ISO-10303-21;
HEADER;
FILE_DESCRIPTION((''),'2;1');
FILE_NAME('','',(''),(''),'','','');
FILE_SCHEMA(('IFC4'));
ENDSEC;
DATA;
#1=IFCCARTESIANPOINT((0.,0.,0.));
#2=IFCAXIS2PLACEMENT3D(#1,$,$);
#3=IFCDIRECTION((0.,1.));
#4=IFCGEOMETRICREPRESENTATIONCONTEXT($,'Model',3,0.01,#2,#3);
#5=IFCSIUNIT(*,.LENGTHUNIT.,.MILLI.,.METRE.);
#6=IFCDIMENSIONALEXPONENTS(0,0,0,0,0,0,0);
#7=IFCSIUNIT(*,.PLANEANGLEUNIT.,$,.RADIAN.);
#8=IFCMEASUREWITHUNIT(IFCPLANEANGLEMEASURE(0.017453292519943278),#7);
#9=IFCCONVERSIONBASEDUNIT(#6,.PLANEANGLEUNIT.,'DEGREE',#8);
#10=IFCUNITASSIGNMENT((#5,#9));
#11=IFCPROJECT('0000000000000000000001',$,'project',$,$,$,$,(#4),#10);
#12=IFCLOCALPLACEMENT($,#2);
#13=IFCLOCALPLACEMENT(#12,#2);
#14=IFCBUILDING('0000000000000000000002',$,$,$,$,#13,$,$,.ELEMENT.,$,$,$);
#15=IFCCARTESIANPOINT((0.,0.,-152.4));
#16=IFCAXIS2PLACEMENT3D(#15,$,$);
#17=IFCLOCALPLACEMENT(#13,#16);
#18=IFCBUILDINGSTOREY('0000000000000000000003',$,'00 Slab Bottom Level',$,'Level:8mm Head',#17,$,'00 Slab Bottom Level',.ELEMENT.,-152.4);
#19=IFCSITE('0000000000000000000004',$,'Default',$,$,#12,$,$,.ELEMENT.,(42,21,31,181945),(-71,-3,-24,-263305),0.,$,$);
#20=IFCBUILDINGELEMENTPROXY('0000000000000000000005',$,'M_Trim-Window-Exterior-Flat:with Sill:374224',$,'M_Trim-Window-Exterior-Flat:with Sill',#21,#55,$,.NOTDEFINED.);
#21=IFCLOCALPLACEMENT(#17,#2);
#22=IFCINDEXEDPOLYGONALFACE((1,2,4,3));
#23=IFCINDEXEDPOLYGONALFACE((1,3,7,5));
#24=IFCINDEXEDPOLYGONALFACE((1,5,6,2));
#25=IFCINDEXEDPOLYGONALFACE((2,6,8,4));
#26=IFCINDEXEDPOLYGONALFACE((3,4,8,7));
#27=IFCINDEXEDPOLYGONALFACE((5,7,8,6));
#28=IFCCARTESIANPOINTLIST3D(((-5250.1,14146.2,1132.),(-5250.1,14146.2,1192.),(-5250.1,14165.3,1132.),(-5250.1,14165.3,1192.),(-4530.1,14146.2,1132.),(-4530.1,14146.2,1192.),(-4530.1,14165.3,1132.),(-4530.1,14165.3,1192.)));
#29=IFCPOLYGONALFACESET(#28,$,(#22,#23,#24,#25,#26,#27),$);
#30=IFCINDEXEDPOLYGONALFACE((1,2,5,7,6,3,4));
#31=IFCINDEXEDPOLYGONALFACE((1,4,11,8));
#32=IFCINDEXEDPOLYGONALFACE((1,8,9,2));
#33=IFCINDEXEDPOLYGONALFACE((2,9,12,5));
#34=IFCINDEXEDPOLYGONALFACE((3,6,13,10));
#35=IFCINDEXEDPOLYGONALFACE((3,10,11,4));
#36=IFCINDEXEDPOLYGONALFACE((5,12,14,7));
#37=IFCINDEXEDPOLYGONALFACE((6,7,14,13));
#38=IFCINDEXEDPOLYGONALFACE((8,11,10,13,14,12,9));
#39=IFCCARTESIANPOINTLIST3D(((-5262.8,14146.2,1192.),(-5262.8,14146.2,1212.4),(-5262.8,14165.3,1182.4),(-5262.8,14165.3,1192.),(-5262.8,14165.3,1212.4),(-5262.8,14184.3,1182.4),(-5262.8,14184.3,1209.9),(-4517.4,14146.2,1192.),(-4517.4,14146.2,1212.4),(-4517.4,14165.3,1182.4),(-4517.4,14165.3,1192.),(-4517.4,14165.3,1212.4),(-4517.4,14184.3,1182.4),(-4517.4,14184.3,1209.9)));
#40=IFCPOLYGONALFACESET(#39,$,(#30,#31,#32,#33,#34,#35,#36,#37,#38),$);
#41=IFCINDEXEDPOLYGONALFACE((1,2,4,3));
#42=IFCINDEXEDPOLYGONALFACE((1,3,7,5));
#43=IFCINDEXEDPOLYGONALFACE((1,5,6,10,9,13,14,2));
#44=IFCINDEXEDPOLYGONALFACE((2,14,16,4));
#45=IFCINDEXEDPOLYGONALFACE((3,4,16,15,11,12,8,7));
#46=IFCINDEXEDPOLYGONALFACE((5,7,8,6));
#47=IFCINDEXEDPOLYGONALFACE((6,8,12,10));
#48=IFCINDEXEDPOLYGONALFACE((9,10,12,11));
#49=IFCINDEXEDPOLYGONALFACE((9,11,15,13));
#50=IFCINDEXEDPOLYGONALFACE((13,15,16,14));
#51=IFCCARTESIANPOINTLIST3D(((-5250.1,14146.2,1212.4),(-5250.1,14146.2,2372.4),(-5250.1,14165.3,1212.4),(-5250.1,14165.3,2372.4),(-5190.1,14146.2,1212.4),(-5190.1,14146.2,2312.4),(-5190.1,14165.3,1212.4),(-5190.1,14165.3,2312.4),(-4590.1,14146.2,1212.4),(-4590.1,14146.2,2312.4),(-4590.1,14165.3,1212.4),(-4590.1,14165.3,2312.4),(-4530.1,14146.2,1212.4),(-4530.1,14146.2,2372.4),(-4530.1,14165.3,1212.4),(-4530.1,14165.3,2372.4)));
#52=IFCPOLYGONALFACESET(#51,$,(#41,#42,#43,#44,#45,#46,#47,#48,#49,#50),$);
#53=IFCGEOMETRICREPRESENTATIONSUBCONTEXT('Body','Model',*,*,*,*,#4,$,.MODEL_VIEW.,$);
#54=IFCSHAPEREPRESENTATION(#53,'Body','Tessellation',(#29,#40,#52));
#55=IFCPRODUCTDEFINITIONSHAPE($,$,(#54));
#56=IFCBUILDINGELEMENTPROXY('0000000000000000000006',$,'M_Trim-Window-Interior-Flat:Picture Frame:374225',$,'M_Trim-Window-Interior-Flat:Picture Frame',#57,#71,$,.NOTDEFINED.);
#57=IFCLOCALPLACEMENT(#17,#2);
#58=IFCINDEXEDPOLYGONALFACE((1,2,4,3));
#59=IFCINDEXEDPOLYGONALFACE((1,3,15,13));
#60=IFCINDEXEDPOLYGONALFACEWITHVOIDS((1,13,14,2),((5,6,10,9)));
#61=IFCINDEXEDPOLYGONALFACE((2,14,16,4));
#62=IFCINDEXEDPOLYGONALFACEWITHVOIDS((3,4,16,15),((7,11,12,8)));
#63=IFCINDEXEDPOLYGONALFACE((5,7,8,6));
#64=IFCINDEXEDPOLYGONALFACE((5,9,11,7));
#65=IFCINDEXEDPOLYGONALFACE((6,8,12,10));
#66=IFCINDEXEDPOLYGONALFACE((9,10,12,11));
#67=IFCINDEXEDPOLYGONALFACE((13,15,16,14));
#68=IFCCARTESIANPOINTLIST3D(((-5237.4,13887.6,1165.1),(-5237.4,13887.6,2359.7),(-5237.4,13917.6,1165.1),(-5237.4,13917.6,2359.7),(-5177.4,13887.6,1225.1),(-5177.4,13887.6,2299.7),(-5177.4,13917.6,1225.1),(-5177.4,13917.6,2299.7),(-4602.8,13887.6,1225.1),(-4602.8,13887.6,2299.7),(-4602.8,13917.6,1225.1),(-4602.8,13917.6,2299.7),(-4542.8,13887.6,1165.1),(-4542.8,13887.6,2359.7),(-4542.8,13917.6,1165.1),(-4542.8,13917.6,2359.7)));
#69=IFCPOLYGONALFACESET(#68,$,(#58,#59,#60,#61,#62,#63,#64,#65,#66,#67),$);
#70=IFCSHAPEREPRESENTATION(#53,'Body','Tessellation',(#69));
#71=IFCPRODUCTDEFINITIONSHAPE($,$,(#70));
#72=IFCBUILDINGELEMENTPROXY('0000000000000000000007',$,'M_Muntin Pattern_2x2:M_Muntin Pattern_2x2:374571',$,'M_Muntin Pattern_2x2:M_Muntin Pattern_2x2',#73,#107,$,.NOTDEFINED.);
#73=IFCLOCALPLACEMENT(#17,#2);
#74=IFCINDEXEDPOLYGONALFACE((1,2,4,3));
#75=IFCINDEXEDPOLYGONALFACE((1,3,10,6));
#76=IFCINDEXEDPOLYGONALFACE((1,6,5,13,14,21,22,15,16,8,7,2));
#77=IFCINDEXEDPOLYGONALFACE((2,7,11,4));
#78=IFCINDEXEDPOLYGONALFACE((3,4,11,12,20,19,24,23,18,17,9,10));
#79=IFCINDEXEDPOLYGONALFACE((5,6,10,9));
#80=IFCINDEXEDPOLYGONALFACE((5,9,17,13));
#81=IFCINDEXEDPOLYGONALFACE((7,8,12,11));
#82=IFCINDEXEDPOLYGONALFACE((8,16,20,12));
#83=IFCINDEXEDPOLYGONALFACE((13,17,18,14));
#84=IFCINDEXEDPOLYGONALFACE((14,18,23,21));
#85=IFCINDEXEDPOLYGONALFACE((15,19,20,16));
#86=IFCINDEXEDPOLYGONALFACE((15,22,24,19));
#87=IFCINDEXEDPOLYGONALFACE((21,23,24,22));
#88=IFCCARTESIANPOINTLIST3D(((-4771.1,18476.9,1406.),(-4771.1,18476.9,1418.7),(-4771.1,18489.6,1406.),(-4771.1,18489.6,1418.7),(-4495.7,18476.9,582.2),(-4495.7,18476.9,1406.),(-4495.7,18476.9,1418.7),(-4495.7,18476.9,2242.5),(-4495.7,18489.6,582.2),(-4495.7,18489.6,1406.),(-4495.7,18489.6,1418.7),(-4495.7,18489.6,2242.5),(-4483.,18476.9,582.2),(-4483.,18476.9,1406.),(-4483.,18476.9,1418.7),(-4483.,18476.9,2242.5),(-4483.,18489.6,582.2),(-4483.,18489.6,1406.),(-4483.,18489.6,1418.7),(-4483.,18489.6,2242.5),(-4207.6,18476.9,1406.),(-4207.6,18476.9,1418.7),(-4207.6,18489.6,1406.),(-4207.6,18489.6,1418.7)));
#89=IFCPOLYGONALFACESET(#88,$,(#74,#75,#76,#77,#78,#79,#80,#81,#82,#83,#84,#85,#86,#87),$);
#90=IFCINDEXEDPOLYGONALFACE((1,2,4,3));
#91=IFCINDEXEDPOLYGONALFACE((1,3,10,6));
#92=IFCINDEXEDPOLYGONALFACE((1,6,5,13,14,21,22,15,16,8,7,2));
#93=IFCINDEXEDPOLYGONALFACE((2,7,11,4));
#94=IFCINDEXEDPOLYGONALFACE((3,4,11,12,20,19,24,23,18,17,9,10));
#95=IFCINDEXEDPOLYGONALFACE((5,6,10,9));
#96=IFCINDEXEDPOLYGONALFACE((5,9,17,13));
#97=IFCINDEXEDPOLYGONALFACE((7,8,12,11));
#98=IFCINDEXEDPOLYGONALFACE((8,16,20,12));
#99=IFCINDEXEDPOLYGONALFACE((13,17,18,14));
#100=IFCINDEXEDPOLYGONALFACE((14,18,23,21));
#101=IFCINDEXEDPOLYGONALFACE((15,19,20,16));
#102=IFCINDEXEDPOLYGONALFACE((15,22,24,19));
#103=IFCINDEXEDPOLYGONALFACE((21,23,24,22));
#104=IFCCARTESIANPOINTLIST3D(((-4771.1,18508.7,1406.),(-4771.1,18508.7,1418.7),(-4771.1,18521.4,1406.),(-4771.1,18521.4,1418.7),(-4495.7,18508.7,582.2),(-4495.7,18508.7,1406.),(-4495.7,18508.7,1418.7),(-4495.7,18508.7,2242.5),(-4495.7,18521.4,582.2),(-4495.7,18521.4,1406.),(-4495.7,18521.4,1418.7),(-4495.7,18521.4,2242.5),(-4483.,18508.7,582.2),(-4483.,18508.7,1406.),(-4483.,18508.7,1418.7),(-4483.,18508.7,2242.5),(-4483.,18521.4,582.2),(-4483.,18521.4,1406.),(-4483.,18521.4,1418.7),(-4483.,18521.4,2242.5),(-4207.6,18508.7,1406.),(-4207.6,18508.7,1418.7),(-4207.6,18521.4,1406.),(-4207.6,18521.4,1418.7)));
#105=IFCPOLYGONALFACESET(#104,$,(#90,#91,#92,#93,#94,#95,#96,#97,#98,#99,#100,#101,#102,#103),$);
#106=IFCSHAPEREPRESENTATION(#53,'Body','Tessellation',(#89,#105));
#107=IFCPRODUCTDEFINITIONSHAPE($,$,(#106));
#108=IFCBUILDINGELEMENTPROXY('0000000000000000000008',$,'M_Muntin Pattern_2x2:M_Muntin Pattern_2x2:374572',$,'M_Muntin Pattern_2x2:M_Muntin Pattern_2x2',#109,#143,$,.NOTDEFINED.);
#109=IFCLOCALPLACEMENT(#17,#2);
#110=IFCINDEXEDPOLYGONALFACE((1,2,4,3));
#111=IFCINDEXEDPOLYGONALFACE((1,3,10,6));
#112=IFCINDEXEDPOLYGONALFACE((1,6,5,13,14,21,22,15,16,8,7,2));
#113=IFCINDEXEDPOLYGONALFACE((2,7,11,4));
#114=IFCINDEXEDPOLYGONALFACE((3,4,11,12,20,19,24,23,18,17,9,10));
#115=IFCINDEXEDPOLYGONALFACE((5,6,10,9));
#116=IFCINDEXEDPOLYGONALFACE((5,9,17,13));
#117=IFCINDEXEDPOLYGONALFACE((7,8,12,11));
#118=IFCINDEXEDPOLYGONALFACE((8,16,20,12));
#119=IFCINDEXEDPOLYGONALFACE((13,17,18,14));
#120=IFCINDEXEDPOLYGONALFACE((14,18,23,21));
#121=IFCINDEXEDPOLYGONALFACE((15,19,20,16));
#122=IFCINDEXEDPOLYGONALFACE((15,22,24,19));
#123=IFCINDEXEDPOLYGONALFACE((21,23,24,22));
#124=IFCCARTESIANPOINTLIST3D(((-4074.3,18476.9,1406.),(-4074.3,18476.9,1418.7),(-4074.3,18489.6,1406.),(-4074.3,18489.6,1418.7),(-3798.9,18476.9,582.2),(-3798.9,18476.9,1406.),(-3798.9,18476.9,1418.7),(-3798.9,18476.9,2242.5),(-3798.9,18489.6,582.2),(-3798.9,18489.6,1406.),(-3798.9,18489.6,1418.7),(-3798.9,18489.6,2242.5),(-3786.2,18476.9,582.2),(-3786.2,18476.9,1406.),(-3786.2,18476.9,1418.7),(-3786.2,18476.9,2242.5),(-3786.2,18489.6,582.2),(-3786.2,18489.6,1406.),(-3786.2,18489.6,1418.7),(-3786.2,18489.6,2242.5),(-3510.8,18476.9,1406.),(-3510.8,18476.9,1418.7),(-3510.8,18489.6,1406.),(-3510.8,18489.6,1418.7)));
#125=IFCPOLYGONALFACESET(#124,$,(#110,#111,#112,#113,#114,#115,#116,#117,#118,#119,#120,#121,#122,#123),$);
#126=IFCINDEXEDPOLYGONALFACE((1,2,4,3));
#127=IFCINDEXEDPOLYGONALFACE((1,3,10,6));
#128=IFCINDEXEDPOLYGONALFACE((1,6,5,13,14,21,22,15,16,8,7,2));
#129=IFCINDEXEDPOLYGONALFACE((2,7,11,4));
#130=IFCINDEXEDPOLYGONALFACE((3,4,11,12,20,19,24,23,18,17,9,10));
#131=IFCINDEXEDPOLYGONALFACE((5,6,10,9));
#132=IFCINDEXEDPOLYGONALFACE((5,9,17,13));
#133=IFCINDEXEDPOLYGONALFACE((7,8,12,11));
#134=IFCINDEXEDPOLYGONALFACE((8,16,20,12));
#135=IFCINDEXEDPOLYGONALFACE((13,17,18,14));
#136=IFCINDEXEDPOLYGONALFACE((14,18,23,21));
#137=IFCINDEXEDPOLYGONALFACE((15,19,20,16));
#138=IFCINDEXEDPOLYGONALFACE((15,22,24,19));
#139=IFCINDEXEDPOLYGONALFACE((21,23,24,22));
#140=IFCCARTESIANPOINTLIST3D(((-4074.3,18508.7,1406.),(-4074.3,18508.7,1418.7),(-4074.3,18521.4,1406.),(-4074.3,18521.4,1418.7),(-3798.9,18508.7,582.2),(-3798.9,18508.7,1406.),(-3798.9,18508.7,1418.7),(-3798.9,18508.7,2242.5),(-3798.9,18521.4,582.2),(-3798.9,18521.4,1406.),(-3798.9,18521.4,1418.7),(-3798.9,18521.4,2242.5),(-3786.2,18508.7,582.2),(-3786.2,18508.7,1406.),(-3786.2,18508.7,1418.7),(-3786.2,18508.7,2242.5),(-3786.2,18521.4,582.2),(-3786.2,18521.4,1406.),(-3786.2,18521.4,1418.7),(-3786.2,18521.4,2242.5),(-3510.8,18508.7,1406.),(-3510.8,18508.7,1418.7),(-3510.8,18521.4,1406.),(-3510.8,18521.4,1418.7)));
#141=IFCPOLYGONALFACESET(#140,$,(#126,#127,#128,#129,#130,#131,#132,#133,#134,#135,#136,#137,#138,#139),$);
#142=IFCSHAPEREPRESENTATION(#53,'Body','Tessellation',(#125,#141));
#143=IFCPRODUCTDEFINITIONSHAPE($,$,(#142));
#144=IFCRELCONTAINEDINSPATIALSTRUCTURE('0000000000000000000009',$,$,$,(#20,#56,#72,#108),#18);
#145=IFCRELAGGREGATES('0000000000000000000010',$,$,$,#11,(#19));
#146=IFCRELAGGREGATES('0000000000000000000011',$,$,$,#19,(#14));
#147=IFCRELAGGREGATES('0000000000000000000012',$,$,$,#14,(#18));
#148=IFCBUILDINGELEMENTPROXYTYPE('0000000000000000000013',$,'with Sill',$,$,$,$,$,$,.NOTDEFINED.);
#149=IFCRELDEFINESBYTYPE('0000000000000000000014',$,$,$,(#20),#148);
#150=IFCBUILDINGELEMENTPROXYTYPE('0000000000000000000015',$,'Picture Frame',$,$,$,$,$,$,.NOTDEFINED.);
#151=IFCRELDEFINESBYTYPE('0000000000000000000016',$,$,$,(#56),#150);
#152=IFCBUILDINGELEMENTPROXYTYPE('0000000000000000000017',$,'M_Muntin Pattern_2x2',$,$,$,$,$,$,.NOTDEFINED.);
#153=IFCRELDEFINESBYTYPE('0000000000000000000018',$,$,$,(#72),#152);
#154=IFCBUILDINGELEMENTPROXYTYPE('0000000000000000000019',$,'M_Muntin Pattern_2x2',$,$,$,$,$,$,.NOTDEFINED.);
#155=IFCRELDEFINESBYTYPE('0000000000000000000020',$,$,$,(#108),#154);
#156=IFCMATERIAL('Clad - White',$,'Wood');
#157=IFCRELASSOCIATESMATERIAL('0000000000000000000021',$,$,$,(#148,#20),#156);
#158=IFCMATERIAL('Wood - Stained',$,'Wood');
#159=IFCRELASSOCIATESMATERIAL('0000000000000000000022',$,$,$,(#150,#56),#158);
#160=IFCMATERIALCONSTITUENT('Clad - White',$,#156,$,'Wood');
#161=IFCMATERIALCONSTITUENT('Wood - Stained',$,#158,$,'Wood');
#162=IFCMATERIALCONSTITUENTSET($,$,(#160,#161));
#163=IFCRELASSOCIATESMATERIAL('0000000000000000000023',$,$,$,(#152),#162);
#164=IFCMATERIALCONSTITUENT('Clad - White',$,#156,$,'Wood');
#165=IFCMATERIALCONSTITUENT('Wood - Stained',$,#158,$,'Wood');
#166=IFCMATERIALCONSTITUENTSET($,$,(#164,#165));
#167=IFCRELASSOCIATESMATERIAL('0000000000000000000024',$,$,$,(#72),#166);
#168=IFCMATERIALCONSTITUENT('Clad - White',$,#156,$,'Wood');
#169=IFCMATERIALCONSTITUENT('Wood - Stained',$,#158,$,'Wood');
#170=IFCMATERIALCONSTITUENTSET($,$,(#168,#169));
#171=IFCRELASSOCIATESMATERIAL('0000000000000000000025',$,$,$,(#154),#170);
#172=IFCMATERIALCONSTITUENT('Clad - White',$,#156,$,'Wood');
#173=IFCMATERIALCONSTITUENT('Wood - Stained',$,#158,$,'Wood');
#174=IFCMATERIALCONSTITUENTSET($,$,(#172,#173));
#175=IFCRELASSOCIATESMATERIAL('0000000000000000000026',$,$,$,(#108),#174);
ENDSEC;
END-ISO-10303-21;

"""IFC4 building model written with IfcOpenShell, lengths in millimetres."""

from ifc_helpers import new_model, entity, si_unit, converted_unit, direction, frame, origin, place, context, subcontext, project, spatial, indexed_curve, outline, extrude, source, transform, mapped, material, constituent, constituent_set, type_object, type_shapes, element, save


model = new_model("IFC4")

# Units and contexts
model_context = context("Model", 3, precision=0.01, world=origin(), true_north=direction((0.0, 1.0)))
body_context = subcontext(model_context, "Body", "Model", "MODEL_VIEW")
ifc_project = project(units=[si_unit("LENGTHUNIT", "METRE", prefix="MILLI"), converted_unit("PLANEANGLEUNIT", "DEGREE", entity("IfcPlaneAngleMeasure", 0.017453292519943278), si_unit("PLANEANGLEUNIT", "RADIAN"), dimensions=[0, 0, 0, 0, 0, 0, 0])], contexts=[model_context])

# Site, building, storey
site_placement = place(None, origin())
site = spatial("IfcSite", under=ifc_project, at=site_placement, Name="Default", CompositionType="ELEMENT", RefLatitude=(42, 21, 31, 181945), RefLongitude=(-71, -3, -24, -263305), RefElevation=0.0)
building_placement = place(site_placement, origin())
building = spatial("IfcBuilding", under=site, at=building_placement, CompositionType="ELEMENT")
storey_placement = place(building_placement, frame((0.0, 0.0, -152.4)))
storey = spatial("IfcBuildingStorey", under=building, at=storey_placement, Name="00 Slab Bottom Level", ObjectType="Level:8mm Head", LongName="00 Slab Bottom Level", CompositionType="ELEMENT", Elevation=-152.4)

# Building element proxies
ifc_material_1 = material(Name="Clad - White", Category="Wood")
ifc_material_2 = material(Name="Wood - Stained", Category="Wood")
building_element_proxy_type_1 = type_object("IfcBuildingElementProxyType", Name="with Sill", PredefinedType="NOTDEFINED", material=ifc_material_1)
shared_shape_1 = source(origin(), body_context, "Body", "SweptSolid", [
    extrude(outline(indexed_curve([(-360.0, -30.0), (360.0, -30.0), (360.0, 30.0), (-360.0, 30.0), (-360.0, -30.0)], self_intersect=False)), frame((0.0, -1150.4, 0.0), z_axis=(0.0, 0.0, 1.0), x_axis=(-1.0, 0.0, 0.0)), (0.0, 0.0, 1.0), 19.0),
    extrude(outline(indexed_curve([(-19.0, -15.2), (0.0, -15.2), (0.0, -5.7), (19.0, -5.7), (19.0, 14.8), (0.0, 14.8), (-19.0, 12.3), (-19.0, -15.2)], self_intersect=False)), frame((-372.7, -1114.8, 19.0), z_axis=(1.0, 0.0, 0.0), x_axis=(0.0, 0.0, -1.0)), (0.0, 0.0, 1.0), 745.4),
    extrude(outline(indexed_curve([(-595.0, -360.0), (565.0, -360.0), (565.0, -300.0), (-535.0, -300.0), (-535.0, 300.0), (565.0, 300.0), (565.0, 360.0), (-595.0, 360.0), (-595.0, -360.0)], self_intersect=False)), frame((0.0, -535.0, 0.0), z_axis=(0.0, 0.0, 1.0), x_axis=(0.0, -1.0, 0.0)), (0.0, 0.0, 1.0), 19.0),
])
type_shapes(building_element_proxy_type_1, [shared_shape_1])
proxy_1_placement = place(storey_placement, frame((-4890.1, 14146.2, 2312.4), z_axis=(0.0, 1.0, 0.0), x_axis=(-1.0, 0.0, 0.0)))
element("IfcBuildingElementProxy", 1, at=proxy_1_placement, inside=storey, type_object=building_element_proxy_type_1, material=ifc_material_1, Name="M_Trim-Window-Exterior-Flat:with Sill:374224", ObjectType="M_Trim-Window-Exterior-Flat:with Sill", PredefinedType="NOTDEFINED", context=body_context, shape_type="MappedRepresentation", body=[
    mapped(shared_shape_1, transform((0.0, 0.0, 0.0), scale=1.0)),
])
building_element_proxy_type_2 = type_object("IfcBuildingElementProxyType", Name="Picture Frame", PredefinedType="NOTDEFINED", material=ifc_material_2)
shared_shape_2 = source(origin(), body_context, "Body", "SweptSolid", [
    extrude(outline(indexed_curve([(-347.3, -597.3), (347.3, -597.3), (347.3, 597.3), (-347.3, 597.3), (-347.3, -597.3)], self_intersect=False), holes=[indexed_curve([(-287.3, -537.3), (-287.3, 537.3), (287.3, 537.3), (287.3, -537.3), (-287.3, -537.3)], self_intersect=False)]), frame((0.0, -550.0, 0.0), z_axis=(0.0, 0.0, 1.0), x_axis=(-1.0, 0.0, 0.0)), (0.0, 0.0, 1.0), 30.0),
])
type_shapes(building_element_proxy_type_2, [shared_shape_2])
proxy_2_placement = place(storey_placement, frame((-4890.1, 13917.6, 2312.4), z_axis=(0.0, -1.0, 0.0), x_axis=(1.0, 0.0, 0.0)))
element("IfcBuildingElementProxy", 2, at=proxy_2_placement, inside=storey, type_object=building_element_proxy_type_2, material=ifc_material_2, Name="M_Trim-Window-Interior-Flat:Picture Frame:374225", ObjectType="M_Trim-Window-Interior-Flat:Picture Frame", PredefinedType="NOTDEFINED", context=body_context, shape_type="MappedRepresentation", body=[
    mapped(shared_shape_2, transform((0.0, 0.0, 0.0), scale=1.0)),
])
ifc_constituent_1 = constituent(ifc_material_1, Name="Clad - White", Category="Wood")
ifc_constituent_2 = constituent(ifc_material_2, Name="Wood - Stained", Category="Wood")
ifc_constituent_set_1 = constituent_set(constituents=[ifc_constituent_1, ifc_constituent_2])
ifc_constituent_3 = constituent(ifc_material_1, Name="Clad - White", Category="Wood")
ifc_constituent_4 = constituent(ifc_material_2, Name="Wood - Stained", Category="Wood")
ifc_constituent_set_2 = constituent_set(constituents=[ifc_constituent_3, ifc_constituent_4])
building_element_proxy_type_3 = type_object("IfcBuildingElementProxyType", Name="M_Muntin Pattern_2x2", PredefinedType="NOTDEFINED", material=ifc_constituent_set_2)
shared_shape_3 = source(origin(), body_context, "Body", "SweptSolid", [
    extrude(outline(indexed_curve([(6.4, -6.4), (830.1, -6.4), (830.1, 6.3), (6.4, 6.3), (6.4, 281.7), (-6.3, 281.7), (-6.3, 6.3), (-830.2, 6.3), (-830.2, -6.4), (-6.3, -6.4), (-6.3, -281.7), (6.4, -281.7), (6.4, -6.4)], self_intersect=False)), frame((0.0, -22.2, 830.1), z_axis=(0.0, 1.0, 0.0), x_axis=(0.0, 0.0, 1.0)), (0.0, 0.0, 1.0), 12.7),
    extrude(outline(indexed_curve([(6.4, -6.4), (830.2, -6.4), (830.2, 6.3), (6.4, 6.3), (6.4, 281.7), (-6.3, 281.7), (-6.3, 6.3), (-830.2, 6.3), (-830.2, -6.4), (-6.3, -6.4), (-6.3, -281.7), (6.4, -281.7), (6.4, -6.4)], self_intersect=False)), frame((0.0, 9.5, 830.2), z_axis=(0.0, 1.0, 0.0), x_axis=(0.0, 0.0, 1.0)), (0.0, 0.0, 1.0), 12.7),
])
type_shapes(building_element_proxy_type_3, [shared_shape_3])
proxy_3_placement = place(storey_placement, frame((-4489.4, 18499.2, 582.2)))
element("IfcBuildingElementProxy", 3, at=proxy_3_placement, inside=storey, type_object=building_element_proxy_type_3, material=ifc_constituent_set_1, Name="M_Muntin Pattern_2x2:M_Muntin Pattern_2x2:374571", ObjectType="M_Muntin Pattern_2x2:M_Muntin Pattern_2x2", PredefinedType="NOTDEFINED", context=body_context, shape_type="MappedRepresentation", body=[
    mapped(shared_shape_3, transform((0.0, 0.0, 0.0), scale=1.0)),
])
ifc_constituent_5 = constituent(ifc_material_1, Name="Clad - White", Category="Wood")
ifc_constituent_6 = constituent(ifc_material_2, Name="Wood - Stained", Category="Wood")
ifc_constituent_set_3 = constituent_set(constituents=[ifc_constituent_5, ifc_constituent_6])
ifc_constituent_7 = constituent(ifc_material_1, Name="Clad - White", Category="Wood")
ifc_constituent_8 = constituent(ifc_material_2, Name="Wood - Stained", Category="Wood")
ifc_constituent_set_4 = constituent_set(constituents=[ifc_constituent_7, ifc_constituent_8])
building_element_proxy_type_4 = type_object("IfcBuildingElementProxyType", Name="M_Muntin Pattern_2x2", PredefinedType="NOTDEFINED", material=ifc_constituent_set_4)
shared_shape_4 = source(origin(), body_context, "Body", "SweptSolid", [
    extrude(outline(indexed_curve([(6.4, -6.4), (830.1, -6.4), (830.1, 6.3), (6.4, 6.3), (6.4, 281.7), (-6.3, 281.7), (-6.3, 6.3), (-830.2, 6.3), (-830.2, -6.4), (-6.3, -6.4), (-6.3, -281.7), (6.4, -281.7), (6.4, -6.4)], self_intersect=False)), frame((0.0, 9.5, 830.1), z_axis=(0.0, 1.0, 0.0), x_axis=(0.0, 0.0, 1.0)), (0.0, 0.0, 1.0), 12.7),
    extrude(outline(indexed_curve([(6.4, -6.4), (830.2, -6.4), (830.2, 6.3), (6.4, 6.3), (6.4, 281.7), (-6.3, 281.7), (-6.3, 6.3), (-830.2, 6.3), (-830.2, -6.4), (-6.3, -6.4), (-6.3, -281.7), (6.4, -281.7), (6.4, -6.4)], self_intersect=False)), frame((0.0, -22.2, 830.2), z_axis=(0.0, 1.0, 0.0), x_axis=(0.0, 0.0, 1.0)), (0.0, 0.0, 1.0), 12.7),
])
type_shapes(building_element_proxy_type_4, [shared_shape_4])
proxy_4_placement = place(storey_placement, frame((-3792.6, 18499.2, 582.2), z_axis=(0.0, 0.0, 1.0), x_axis=(-1.0, 0.0, 0.0)))
element("IfcBuildingElementProxy", 4, at=proxy_4_placement, inside=storey, type_object=building_element_proxy_type_4, material=ifc_constituent_set_3, Name="M_Muntin Pattern_2x2:M_Muntin Pattern_2x2:374572", ObjectType="M_Muntin Pattern_2x2:M_Muntin Pattern_2x2", PredefinedType="NOTDEFINED", context=body_context, shape_type="MappedRepresentation", body=[
    mapped(shared_shape_4, transform((0.0, 0.0, 0.0), scale=1.0)),
])

save(model, "model.ifc")
